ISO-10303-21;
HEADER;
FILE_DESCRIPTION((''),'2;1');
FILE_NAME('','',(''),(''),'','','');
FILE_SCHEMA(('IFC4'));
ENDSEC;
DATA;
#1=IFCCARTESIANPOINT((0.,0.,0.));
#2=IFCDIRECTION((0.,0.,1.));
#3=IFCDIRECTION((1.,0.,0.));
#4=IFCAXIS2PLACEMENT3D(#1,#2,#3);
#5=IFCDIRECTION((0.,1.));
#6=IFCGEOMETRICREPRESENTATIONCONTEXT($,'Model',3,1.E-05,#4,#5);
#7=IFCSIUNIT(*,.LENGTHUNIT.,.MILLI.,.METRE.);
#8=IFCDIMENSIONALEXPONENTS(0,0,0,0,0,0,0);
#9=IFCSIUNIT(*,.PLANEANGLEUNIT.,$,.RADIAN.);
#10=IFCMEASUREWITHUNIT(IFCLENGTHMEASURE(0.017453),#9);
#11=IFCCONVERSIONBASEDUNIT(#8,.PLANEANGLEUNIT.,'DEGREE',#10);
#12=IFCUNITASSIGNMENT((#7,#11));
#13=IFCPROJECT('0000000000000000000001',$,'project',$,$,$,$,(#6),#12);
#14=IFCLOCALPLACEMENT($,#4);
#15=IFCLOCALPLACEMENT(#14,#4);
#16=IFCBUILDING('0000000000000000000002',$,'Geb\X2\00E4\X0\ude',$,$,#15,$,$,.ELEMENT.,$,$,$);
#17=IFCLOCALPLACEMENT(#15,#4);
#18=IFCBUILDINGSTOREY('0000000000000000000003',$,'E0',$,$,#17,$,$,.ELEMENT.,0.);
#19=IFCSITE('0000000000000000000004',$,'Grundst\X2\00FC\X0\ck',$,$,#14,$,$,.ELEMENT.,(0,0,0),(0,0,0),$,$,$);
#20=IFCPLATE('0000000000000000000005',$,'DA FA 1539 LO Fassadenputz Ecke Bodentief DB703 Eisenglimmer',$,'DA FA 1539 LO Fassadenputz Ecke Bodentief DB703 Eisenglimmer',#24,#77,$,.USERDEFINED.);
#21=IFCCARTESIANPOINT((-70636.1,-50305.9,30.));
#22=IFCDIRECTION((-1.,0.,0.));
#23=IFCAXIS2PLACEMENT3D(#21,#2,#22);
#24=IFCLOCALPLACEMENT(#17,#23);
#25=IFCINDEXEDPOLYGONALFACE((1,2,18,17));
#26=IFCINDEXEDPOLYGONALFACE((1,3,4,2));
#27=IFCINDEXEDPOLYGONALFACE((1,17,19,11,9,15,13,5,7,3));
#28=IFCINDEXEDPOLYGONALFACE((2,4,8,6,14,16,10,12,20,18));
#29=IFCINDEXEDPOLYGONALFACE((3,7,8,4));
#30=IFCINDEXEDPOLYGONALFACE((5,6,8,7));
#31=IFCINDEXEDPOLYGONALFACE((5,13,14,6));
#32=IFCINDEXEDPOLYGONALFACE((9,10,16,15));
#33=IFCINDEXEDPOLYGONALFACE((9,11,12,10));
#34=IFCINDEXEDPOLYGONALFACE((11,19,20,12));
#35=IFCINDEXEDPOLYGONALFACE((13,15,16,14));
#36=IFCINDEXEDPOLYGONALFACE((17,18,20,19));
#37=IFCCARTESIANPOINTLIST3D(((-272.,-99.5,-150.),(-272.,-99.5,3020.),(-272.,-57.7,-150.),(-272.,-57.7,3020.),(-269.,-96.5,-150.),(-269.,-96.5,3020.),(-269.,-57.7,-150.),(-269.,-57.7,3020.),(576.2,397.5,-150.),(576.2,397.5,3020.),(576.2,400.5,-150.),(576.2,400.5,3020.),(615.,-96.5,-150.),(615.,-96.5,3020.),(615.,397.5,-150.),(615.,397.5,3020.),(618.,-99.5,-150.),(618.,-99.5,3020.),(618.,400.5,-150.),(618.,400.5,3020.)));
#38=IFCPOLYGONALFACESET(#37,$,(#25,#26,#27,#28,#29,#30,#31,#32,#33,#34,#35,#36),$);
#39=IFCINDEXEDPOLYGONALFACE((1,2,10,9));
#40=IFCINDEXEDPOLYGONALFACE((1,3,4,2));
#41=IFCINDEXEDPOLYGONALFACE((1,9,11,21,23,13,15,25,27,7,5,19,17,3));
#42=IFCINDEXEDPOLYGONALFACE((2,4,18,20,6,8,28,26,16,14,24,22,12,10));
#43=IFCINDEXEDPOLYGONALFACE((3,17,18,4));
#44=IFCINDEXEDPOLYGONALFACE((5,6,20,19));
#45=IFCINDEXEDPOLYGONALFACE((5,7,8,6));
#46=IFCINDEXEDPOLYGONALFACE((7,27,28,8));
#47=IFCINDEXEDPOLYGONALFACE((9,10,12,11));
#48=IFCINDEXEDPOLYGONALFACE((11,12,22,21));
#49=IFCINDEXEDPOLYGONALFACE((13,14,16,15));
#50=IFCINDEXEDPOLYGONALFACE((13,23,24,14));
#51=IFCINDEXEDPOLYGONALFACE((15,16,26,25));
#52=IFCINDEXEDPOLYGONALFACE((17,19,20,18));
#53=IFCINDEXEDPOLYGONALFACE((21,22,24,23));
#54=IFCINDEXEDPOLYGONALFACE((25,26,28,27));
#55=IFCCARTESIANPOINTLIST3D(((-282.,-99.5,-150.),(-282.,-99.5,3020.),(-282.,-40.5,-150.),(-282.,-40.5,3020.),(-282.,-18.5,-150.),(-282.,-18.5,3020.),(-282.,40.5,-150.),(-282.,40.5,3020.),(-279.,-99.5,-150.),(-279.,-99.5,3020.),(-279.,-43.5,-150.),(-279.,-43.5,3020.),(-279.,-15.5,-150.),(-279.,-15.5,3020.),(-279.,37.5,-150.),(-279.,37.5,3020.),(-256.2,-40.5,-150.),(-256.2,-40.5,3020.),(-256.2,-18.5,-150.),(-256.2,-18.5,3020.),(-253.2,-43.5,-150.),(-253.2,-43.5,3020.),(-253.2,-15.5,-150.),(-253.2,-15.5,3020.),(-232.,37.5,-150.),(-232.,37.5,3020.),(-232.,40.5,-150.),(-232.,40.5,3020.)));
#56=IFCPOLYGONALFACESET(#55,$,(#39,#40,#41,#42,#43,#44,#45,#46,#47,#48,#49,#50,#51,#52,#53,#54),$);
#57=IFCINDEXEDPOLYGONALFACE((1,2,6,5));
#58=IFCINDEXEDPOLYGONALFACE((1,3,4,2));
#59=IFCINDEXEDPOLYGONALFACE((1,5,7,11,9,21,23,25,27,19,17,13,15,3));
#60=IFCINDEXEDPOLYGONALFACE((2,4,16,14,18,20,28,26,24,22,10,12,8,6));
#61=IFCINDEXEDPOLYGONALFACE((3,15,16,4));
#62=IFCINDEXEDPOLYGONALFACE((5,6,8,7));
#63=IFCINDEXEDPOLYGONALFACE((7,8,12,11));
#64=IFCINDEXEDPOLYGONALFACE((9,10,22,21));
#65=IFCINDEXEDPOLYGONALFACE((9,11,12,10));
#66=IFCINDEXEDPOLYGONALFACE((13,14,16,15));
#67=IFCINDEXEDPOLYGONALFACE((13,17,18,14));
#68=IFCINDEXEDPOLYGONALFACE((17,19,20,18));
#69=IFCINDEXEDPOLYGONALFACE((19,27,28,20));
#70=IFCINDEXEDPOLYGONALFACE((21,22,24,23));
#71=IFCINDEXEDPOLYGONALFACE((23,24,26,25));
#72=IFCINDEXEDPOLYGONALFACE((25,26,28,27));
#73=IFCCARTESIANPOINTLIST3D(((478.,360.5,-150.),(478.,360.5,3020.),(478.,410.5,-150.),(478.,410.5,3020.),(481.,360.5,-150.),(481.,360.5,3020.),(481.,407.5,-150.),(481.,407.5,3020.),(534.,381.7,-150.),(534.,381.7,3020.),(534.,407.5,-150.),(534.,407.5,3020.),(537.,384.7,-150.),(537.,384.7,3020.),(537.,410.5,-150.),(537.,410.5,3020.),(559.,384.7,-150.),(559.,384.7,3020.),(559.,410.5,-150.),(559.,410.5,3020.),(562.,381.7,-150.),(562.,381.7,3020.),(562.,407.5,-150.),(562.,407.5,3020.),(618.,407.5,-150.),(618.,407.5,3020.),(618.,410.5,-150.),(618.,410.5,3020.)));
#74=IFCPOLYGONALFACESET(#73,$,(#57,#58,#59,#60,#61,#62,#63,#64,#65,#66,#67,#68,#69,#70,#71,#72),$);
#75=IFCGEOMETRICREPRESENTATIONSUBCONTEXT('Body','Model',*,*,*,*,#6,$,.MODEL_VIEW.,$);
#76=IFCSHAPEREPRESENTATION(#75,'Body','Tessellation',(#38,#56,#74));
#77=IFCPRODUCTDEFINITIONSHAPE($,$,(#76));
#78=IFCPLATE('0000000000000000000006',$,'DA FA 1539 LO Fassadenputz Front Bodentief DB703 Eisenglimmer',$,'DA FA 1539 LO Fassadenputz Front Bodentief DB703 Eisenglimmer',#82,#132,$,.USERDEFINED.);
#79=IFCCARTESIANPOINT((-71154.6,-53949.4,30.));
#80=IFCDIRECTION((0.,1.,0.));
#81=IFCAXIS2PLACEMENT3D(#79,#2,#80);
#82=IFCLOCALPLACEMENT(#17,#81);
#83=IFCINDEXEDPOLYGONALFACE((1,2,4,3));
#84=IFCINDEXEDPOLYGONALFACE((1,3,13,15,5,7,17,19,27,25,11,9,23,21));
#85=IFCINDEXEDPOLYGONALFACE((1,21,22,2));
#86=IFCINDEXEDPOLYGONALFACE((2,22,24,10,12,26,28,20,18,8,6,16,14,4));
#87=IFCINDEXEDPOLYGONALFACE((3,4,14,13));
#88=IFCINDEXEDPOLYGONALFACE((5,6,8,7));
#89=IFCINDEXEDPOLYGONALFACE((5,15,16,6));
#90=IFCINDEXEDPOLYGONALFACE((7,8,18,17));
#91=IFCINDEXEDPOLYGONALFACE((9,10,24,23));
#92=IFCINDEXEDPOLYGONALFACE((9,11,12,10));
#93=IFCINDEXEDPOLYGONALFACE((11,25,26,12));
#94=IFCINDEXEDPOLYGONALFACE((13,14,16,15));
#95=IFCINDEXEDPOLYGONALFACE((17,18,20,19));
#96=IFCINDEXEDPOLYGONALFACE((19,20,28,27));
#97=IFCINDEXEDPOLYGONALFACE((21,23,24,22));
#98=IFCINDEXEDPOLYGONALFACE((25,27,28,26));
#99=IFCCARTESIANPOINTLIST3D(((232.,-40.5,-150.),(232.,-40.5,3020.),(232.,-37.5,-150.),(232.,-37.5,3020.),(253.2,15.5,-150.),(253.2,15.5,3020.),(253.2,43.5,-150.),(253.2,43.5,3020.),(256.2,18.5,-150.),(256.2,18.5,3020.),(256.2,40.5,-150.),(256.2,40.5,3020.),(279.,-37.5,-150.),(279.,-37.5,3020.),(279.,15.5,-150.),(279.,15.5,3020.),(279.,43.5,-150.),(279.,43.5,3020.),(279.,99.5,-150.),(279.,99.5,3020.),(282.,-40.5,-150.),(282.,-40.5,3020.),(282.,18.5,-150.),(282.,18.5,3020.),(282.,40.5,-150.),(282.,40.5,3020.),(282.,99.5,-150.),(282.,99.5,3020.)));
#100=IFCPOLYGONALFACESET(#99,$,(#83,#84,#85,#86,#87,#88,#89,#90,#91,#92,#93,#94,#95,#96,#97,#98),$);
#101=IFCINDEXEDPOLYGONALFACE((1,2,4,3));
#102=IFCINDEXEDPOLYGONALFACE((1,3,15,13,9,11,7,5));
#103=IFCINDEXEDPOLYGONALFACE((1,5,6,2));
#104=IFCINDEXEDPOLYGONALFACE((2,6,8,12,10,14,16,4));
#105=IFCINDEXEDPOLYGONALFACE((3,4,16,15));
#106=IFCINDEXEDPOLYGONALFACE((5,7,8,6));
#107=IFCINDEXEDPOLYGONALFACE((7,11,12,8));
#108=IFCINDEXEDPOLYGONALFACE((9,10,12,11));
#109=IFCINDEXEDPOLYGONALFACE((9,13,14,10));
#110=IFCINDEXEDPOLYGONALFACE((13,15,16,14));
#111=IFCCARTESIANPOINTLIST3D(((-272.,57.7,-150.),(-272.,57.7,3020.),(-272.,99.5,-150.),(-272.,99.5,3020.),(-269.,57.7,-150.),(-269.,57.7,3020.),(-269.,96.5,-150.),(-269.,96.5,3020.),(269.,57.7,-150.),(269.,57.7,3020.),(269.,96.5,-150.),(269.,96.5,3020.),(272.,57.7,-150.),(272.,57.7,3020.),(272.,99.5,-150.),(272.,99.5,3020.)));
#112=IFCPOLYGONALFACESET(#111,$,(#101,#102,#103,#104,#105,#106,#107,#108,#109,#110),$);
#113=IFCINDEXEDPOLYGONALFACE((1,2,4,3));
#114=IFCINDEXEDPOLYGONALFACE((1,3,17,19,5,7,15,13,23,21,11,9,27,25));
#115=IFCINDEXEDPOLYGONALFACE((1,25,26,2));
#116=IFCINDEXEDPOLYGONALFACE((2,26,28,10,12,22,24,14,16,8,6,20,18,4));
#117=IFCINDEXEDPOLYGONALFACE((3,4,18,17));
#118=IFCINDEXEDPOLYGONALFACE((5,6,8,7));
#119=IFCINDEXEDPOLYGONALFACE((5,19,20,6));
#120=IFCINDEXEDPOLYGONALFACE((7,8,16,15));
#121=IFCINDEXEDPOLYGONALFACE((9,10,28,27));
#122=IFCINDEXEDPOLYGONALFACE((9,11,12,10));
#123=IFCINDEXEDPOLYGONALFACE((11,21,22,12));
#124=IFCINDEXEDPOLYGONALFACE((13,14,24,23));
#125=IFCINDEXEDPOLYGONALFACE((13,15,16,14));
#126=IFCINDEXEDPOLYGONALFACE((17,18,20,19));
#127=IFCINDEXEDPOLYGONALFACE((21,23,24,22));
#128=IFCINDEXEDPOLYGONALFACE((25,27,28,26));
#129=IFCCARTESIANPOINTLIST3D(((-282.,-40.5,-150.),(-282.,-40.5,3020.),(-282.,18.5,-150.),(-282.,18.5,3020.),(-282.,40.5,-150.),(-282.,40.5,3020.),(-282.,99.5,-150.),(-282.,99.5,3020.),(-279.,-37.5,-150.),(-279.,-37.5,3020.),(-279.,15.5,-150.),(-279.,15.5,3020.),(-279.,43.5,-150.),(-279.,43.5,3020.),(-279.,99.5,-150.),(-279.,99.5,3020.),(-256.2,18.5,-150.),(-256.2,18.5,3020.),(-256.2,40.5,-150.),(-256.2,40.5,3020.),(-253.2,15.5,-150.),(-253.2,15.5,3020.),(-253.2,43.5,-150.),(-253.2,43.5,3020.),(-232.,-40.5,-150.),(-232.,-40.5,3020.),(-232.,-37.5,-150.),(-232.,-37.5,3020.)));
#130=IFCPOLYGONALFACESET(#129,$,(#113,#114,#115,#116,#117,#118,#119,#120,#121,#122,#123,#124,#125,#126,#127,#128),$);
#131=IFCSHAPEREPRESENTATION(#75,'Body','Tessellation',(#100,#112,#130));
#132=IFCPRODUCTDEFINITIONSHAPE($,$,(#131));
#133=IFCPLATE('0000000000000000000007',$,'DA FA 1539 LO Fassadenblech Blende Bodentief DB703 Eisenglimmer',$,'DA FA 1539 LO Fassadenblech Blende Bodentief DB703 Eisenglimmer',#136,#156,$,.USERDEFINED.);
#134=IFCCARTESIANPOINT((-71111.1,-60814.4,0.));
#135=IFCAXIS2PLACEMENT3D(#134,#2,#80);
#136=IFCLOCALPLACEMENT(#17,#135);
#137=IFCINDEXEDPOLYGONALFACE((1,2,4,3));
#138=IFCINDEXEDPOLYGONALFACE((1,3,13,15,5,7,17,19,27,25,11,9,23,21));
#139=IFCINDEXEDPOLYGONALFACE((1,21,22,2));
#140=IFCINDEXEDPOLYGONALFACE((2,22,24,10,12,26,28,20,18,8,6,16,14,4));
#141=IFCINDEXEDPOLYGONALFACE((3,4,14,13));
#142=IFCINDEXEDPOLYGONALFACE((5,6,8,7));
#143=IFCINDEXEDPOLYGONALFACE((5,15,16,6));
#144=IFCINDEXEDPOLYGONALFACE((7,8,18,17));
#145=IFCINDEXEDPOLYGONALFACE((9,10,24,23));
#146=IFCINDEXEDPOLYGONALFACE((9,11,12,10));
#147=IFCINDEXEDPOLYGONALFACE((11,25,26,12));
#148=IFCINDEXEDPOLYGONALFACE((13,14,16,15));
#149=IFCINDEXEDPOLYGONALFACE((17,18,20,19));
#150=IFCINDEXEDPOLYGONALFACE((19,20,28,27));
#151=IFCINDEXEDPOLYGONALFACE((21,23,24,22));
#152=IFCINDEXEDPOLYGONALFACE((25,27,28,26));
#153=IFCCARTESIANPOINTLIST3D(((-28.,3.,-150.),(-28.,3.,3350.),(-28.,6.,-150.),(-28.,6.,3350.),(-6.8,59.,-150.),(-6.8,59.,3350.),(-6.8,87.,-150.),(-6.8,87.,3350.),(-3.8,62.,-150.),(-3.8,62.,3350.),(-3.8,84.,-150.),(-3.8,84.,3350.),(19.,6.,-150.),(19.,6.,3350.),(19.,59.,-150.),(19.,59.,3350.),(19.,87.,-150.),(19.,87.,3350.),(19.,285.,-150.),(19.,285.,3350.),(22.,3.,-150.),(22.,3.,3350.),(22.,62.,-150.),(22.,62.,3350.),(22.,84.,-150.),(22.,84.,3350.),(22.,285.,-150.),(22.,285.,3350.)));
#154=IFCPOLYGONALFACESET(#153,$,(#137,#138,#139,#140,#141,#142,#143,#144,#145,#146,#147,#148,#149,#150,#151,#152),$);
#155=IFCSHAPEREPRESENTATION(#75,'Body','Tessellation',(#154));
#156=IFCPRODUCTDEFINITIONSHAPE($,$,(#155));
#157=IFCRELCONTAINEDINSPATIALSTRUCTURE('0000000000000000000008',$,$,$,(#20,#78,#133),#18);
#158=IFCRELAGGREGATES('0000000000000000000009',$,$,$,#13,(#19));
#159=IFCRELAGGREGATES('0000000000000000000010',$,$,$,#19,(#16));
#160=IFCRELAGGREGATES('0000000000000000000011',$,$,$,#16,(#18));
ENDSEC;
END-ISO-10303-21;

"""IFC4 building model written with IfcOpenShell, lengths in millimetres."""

from ifc_helpers import new_model, entity, si_unit, converted_unit, direction, frame, origin_with_axes, place, context, subcontext, project, spatial, line, indexed_curve, outline, extrude, source, transform, mapped, element, save


model = new_model("IFC4")

# Units and contexts
model_context = context("Model", 3, precision=1e-05, world=origin_with_axes(), true_north=direction((0.0, 1.0)))
body_context = subcontext(model_context, "Body", "Model", "MODEL_VIEW")
ifc_project = project(units=[si_unit("LENGTHUNIT", "METRE", prefix="MILLI"), converted_unit("PLANEANGLEUNIT", "DEGREE", entity("IfcLengthMeasure", 0.017453), si_unit("PLANEANGLEUNIT", "RADIAN"), dimensions=[0, 0, 0, 0, 0, 0, 0])], contexts=[model_context])

# Site, building, storey
site_placement = place(None, origin_with_axes())
site = spatial("IfcSite", under=ifc_project, at=site_placement, Name="Grundstück", CompositionType="ELEMENT", RefLatitude=(0, 0, 0), RefLongitude=(0, 0, 0))
building_placement = place(site_placement, origin_with_axes())
building = spatial("IfcBuilding", under=site, at=building_placement, Name="Gebäude", CompositionType="ELEMENT")
storey_placement = place(building_placement, origin_with_axes())
storey = spatial("IfcBuildingStorey", under=building, at=storey_placement, Name="E0", CompositionType="ELEMENT", Elevation=0.0)

# Plates
shared_shape_1 = source(origin_with_axes(), body_context, "Body", "SweptSolid", [
    extrude(outline(indexed_curve([(618.0, -400.5), (576.2, -400.5), (576.2, -397.5), (615.0, -397.5), (615.0, 96.5), (-269.0, 96.5), (-269.0, 57.7), (-272.0, 57.7), (-272.0, 99.5), (618.0, 99.5)], segments=[line(1, 2), line(2, 3), line(3, 4), line(4, 5), line(5, 6), line(6, 7), line(7, 8), line(8, 9), line(9, 10), line(10, 1)])), frame((0.0, 0.0, -150.0), z_axis=(0.0, 0.0, 1.0), x_axis=(1.0, 0.0, 0.0)), (0.0, 0.0, 1.0), 3170.0),
    extrude(outline(indexed_curve([(-282.0, 99.5), (-282.0, 40.5), (-256.2, 40.5), (-256.2, 18.5), (-282.0, 18.5), (-282.0, -40.5), (-232.0, -40.5), (-232.0, -37.5), (-279.0, -37.5), (-279.0, 15.5), (-253.2, 15.5), (-253.2, 43.5), (-279.0, 43.5), (-279.0, 99.5)], segments=[line(1, 2), line(2, 3), line(3, 4), line(4, 5), line(5, 6), line(6, 7), line(7, 8), line(8, 9), line(9, 10), line(10, 11), line(11, 12), line(12, 13), line(13, 14), line(14, 1)])), frame((0.0, 0.0, -150.0), z_axis=(0.0, 0.0, 1.0), x_axis=(1.0, 0.0, 0.0)), (0.0, 0.0, 1.0), 3170.0),
    extrude(outline(indexed_curve([(618.0, -410.5), (559.0, -410.5), (559.0, -384.7), (537.0, -384.7), (537.0, -410.5), (478.0, -410.5), (478.0, -360.5), (481.0, -360.5), (481.0, -407.5), (534.0, -407.5), (534.0, -381.7), (562.0, -381.7), (562.0, -407.5), (618.0, -407.5)], segments=[line(1, 2), line(2, 3), line(3, 4), line(4, 5), line(5, 6), line(6, 7), line(7, 8), line(8, 9), line(9, 10), line(10, 11), line(11, 12), line(12, 13), line(13, 14), line(14, 1)])), frame((0.0, 0.0, -150.0), z_axis=(0.0, 0.0, 1.0), x_axis=(1.0, 0.0, 0.0)), (0.0, 0.0, 1.0), 3170.0),
])
plate_1_placement = place(storey_placement, frame((-70636.1, -50305.9, 30.0), z_axis=(0.0, 0.0, 1.0), x_axis=(-1.0, 0.0, 0.0)))
element("IfcPlate", 1, at=plate_1_placement, inside=storey, Name="DA FA 1539 LO Fassadenputz Ecke Bodentief DB703 Eisenglimmer", ObjectType="DA FA 1539 LO Fassadenputz Ecke Bodentief DB703 Eisenglimmer", PredefinedType="USERDEFINED", context=body_context, shape_type="MappedRepresentation", body=[
    mapped(shared_shape_1, transform((0.0, 0.0, 0.0), x_axis=(1.0, 0.0, 0.0), y_axis=(0.0, -1.0, 0.0), z_axis=(0.0, 0.0, 1.0), scale=1.0)),
])
shared_shape_2 = source(origin_with_axes(), body_context, "Body", "SweptSolid", [
    extrude(outline(indexed_curve([(282.0, 99.5), (282.0, 40.5), (256.2, 40.5), (256.2, 18.5), (282.0, 18.5), (282.0, -40.5), (232.0, -40.5), (232.0, -37.5), (279.0, -37.5), (279.0, 15.5), (253.2, 15.5), (253.2, 43.5), (279.0, 43.5), (279.0, 99.5)], segments=[line(1, 2), line(2, 3), line(3, 4), line(4, 5), line(5, 6), line(6, 7), line(7, 8), line(8, 9), line(9, 10), line(10, 11), line(11, 12), line(12, 13), line(13, 14), line(14, 1)])), frame((0.0, 0.0, -150.0), z_axis=(0.0, 0.0, 1.0), x_axis=(1.0, 0.0, 0.0)), (0.0, 0.0, 1.0), 3170.0),
    extrude(outline(indexed_curve([(272.0, 99.5), (272.0, 57.7), (269.0, 57.7), (269.0, 96.5), (-269.0, 96.5), (-269.0, 57.7), (-272.0, 57.7), (-272.0, 99.5)], segments=[line(1, 2), line(2, 3), line(3, 4), line(4, 5), line(5, 6), line(6, 7), line(7, 8), line(8, 1)])), frame((0.0, 0.0, -150.0), z_axis=(0.0, 0.0, 1.0), x_axis=(1.0, 0.0, 0.0)), (0.0, 0.0, 1.0), 3170.0),
    extrude(outline(indexed_curve([(-282.0, 99.5), (-282.0, 40.5), (-256.2, 40.5), (-256.2, 18.5), (-282.0, 18.5), (-282.0, -40.5), (-232.0, -40.5), (-232.0, -37.5), (-279.0, -37.5), (-279.0, 15.5), (-253.2, 15.5), (-253.2, 43.5), (-279.0, 43.5), (-279.0, 99.5)], segments=[line(1, 2), line(2, 3), line(3, 4), line(4, 5), line(5, 6), line(6, 7), line(7, 8), line(8, 9), line(9, 10), line(10, 11), line(11, 12), line(12, 13), line(13, 14), line(14, 1)])), frame((0.0, 0.0, -150.0), z_axis=(0.0, 0.0, 1.0), x_axis=(1.0, 0.0, 0.0)), (0.0, 0.0, 1.0), 3170.0),
])
plate_2_placement = place(storey_placement, frame((-71154.6, -53949.4, 30.0), z_axis=(0.0, 0.0, 1.0), x_axis=(0.0, 1.0, 0.0)))
element("IfcPlate", 2, at=plate_2_placement, inside=storey, Name="DA FA 1539 LO Fassadenputz Front Bodentief DB703 Eisenglimmer", ObjectType="DA FA 1539 LO Fassadenputz Front Bodentief DB703 Eisenglimmer", PredefinedType="USERDEFINED", context=body_context, shape_type="MappedRepresentation", body=[
    mapped(shared_shape_2, transform((0.0, 0.0, 0.0), x_axis=(1.0, 0.0, 0.0), y_axis=(0.0, 1.0, 0.0), z_axis=(0.0, 0.0, 1.0), scale=1.0)),
])
plate_3_placement = place(storey_placement, frame((-71111.1, -60814.4, 0.0), z_axis=(0.0, 0.0, 1.0), x_axis=(0.0, 1.0, 0.0)))
element("IfcPlate", 3, at=plate_3_placement, inside=storey, Name="DA FA 1539 LO Fassadenblech Blende Bodentief DB703 Eisenglimmer", ObjectType="DA FA 1539 LO Fassadenblech Blende Bodentief DB703 Eisenglimmer", PredefinedType="USERDEFINED", context=body_context, shape_type="SweptSolid", body=[
    extrude(outline(indexed_curve([(22.0, 285.0), (22.0, 84.0), (-3.8, 84.0), (-3.8, 62.0), (22.0, 62.0), (22.0, 3.0), (-28.0, 3.0), (-28.0, 6.0), (19.0, 6.0), (19.0, 59.0), (-6.8, 59.0), (-6.8, 87.0), (19.0, 87.0), (19.0, 285.0)], segments=[line(1, 2), line(2, 3), line(3, 4), line(4, 5), line(5, 6), line(6, 7), line(7, 8), line(8, 9), line(9, 10), line(10, 11), line(11, 12), line(12, 13), line(13, 14), line(14, 1)])), frame((0.0, 0.0, -150.0), z_axis=(0.0, 0.0, 1.0), x_axis=(1.0, 0.0, 0.0)), (0.0, 0.0, 1.0), 3500.0),
])

save(model, "model.ifc")
